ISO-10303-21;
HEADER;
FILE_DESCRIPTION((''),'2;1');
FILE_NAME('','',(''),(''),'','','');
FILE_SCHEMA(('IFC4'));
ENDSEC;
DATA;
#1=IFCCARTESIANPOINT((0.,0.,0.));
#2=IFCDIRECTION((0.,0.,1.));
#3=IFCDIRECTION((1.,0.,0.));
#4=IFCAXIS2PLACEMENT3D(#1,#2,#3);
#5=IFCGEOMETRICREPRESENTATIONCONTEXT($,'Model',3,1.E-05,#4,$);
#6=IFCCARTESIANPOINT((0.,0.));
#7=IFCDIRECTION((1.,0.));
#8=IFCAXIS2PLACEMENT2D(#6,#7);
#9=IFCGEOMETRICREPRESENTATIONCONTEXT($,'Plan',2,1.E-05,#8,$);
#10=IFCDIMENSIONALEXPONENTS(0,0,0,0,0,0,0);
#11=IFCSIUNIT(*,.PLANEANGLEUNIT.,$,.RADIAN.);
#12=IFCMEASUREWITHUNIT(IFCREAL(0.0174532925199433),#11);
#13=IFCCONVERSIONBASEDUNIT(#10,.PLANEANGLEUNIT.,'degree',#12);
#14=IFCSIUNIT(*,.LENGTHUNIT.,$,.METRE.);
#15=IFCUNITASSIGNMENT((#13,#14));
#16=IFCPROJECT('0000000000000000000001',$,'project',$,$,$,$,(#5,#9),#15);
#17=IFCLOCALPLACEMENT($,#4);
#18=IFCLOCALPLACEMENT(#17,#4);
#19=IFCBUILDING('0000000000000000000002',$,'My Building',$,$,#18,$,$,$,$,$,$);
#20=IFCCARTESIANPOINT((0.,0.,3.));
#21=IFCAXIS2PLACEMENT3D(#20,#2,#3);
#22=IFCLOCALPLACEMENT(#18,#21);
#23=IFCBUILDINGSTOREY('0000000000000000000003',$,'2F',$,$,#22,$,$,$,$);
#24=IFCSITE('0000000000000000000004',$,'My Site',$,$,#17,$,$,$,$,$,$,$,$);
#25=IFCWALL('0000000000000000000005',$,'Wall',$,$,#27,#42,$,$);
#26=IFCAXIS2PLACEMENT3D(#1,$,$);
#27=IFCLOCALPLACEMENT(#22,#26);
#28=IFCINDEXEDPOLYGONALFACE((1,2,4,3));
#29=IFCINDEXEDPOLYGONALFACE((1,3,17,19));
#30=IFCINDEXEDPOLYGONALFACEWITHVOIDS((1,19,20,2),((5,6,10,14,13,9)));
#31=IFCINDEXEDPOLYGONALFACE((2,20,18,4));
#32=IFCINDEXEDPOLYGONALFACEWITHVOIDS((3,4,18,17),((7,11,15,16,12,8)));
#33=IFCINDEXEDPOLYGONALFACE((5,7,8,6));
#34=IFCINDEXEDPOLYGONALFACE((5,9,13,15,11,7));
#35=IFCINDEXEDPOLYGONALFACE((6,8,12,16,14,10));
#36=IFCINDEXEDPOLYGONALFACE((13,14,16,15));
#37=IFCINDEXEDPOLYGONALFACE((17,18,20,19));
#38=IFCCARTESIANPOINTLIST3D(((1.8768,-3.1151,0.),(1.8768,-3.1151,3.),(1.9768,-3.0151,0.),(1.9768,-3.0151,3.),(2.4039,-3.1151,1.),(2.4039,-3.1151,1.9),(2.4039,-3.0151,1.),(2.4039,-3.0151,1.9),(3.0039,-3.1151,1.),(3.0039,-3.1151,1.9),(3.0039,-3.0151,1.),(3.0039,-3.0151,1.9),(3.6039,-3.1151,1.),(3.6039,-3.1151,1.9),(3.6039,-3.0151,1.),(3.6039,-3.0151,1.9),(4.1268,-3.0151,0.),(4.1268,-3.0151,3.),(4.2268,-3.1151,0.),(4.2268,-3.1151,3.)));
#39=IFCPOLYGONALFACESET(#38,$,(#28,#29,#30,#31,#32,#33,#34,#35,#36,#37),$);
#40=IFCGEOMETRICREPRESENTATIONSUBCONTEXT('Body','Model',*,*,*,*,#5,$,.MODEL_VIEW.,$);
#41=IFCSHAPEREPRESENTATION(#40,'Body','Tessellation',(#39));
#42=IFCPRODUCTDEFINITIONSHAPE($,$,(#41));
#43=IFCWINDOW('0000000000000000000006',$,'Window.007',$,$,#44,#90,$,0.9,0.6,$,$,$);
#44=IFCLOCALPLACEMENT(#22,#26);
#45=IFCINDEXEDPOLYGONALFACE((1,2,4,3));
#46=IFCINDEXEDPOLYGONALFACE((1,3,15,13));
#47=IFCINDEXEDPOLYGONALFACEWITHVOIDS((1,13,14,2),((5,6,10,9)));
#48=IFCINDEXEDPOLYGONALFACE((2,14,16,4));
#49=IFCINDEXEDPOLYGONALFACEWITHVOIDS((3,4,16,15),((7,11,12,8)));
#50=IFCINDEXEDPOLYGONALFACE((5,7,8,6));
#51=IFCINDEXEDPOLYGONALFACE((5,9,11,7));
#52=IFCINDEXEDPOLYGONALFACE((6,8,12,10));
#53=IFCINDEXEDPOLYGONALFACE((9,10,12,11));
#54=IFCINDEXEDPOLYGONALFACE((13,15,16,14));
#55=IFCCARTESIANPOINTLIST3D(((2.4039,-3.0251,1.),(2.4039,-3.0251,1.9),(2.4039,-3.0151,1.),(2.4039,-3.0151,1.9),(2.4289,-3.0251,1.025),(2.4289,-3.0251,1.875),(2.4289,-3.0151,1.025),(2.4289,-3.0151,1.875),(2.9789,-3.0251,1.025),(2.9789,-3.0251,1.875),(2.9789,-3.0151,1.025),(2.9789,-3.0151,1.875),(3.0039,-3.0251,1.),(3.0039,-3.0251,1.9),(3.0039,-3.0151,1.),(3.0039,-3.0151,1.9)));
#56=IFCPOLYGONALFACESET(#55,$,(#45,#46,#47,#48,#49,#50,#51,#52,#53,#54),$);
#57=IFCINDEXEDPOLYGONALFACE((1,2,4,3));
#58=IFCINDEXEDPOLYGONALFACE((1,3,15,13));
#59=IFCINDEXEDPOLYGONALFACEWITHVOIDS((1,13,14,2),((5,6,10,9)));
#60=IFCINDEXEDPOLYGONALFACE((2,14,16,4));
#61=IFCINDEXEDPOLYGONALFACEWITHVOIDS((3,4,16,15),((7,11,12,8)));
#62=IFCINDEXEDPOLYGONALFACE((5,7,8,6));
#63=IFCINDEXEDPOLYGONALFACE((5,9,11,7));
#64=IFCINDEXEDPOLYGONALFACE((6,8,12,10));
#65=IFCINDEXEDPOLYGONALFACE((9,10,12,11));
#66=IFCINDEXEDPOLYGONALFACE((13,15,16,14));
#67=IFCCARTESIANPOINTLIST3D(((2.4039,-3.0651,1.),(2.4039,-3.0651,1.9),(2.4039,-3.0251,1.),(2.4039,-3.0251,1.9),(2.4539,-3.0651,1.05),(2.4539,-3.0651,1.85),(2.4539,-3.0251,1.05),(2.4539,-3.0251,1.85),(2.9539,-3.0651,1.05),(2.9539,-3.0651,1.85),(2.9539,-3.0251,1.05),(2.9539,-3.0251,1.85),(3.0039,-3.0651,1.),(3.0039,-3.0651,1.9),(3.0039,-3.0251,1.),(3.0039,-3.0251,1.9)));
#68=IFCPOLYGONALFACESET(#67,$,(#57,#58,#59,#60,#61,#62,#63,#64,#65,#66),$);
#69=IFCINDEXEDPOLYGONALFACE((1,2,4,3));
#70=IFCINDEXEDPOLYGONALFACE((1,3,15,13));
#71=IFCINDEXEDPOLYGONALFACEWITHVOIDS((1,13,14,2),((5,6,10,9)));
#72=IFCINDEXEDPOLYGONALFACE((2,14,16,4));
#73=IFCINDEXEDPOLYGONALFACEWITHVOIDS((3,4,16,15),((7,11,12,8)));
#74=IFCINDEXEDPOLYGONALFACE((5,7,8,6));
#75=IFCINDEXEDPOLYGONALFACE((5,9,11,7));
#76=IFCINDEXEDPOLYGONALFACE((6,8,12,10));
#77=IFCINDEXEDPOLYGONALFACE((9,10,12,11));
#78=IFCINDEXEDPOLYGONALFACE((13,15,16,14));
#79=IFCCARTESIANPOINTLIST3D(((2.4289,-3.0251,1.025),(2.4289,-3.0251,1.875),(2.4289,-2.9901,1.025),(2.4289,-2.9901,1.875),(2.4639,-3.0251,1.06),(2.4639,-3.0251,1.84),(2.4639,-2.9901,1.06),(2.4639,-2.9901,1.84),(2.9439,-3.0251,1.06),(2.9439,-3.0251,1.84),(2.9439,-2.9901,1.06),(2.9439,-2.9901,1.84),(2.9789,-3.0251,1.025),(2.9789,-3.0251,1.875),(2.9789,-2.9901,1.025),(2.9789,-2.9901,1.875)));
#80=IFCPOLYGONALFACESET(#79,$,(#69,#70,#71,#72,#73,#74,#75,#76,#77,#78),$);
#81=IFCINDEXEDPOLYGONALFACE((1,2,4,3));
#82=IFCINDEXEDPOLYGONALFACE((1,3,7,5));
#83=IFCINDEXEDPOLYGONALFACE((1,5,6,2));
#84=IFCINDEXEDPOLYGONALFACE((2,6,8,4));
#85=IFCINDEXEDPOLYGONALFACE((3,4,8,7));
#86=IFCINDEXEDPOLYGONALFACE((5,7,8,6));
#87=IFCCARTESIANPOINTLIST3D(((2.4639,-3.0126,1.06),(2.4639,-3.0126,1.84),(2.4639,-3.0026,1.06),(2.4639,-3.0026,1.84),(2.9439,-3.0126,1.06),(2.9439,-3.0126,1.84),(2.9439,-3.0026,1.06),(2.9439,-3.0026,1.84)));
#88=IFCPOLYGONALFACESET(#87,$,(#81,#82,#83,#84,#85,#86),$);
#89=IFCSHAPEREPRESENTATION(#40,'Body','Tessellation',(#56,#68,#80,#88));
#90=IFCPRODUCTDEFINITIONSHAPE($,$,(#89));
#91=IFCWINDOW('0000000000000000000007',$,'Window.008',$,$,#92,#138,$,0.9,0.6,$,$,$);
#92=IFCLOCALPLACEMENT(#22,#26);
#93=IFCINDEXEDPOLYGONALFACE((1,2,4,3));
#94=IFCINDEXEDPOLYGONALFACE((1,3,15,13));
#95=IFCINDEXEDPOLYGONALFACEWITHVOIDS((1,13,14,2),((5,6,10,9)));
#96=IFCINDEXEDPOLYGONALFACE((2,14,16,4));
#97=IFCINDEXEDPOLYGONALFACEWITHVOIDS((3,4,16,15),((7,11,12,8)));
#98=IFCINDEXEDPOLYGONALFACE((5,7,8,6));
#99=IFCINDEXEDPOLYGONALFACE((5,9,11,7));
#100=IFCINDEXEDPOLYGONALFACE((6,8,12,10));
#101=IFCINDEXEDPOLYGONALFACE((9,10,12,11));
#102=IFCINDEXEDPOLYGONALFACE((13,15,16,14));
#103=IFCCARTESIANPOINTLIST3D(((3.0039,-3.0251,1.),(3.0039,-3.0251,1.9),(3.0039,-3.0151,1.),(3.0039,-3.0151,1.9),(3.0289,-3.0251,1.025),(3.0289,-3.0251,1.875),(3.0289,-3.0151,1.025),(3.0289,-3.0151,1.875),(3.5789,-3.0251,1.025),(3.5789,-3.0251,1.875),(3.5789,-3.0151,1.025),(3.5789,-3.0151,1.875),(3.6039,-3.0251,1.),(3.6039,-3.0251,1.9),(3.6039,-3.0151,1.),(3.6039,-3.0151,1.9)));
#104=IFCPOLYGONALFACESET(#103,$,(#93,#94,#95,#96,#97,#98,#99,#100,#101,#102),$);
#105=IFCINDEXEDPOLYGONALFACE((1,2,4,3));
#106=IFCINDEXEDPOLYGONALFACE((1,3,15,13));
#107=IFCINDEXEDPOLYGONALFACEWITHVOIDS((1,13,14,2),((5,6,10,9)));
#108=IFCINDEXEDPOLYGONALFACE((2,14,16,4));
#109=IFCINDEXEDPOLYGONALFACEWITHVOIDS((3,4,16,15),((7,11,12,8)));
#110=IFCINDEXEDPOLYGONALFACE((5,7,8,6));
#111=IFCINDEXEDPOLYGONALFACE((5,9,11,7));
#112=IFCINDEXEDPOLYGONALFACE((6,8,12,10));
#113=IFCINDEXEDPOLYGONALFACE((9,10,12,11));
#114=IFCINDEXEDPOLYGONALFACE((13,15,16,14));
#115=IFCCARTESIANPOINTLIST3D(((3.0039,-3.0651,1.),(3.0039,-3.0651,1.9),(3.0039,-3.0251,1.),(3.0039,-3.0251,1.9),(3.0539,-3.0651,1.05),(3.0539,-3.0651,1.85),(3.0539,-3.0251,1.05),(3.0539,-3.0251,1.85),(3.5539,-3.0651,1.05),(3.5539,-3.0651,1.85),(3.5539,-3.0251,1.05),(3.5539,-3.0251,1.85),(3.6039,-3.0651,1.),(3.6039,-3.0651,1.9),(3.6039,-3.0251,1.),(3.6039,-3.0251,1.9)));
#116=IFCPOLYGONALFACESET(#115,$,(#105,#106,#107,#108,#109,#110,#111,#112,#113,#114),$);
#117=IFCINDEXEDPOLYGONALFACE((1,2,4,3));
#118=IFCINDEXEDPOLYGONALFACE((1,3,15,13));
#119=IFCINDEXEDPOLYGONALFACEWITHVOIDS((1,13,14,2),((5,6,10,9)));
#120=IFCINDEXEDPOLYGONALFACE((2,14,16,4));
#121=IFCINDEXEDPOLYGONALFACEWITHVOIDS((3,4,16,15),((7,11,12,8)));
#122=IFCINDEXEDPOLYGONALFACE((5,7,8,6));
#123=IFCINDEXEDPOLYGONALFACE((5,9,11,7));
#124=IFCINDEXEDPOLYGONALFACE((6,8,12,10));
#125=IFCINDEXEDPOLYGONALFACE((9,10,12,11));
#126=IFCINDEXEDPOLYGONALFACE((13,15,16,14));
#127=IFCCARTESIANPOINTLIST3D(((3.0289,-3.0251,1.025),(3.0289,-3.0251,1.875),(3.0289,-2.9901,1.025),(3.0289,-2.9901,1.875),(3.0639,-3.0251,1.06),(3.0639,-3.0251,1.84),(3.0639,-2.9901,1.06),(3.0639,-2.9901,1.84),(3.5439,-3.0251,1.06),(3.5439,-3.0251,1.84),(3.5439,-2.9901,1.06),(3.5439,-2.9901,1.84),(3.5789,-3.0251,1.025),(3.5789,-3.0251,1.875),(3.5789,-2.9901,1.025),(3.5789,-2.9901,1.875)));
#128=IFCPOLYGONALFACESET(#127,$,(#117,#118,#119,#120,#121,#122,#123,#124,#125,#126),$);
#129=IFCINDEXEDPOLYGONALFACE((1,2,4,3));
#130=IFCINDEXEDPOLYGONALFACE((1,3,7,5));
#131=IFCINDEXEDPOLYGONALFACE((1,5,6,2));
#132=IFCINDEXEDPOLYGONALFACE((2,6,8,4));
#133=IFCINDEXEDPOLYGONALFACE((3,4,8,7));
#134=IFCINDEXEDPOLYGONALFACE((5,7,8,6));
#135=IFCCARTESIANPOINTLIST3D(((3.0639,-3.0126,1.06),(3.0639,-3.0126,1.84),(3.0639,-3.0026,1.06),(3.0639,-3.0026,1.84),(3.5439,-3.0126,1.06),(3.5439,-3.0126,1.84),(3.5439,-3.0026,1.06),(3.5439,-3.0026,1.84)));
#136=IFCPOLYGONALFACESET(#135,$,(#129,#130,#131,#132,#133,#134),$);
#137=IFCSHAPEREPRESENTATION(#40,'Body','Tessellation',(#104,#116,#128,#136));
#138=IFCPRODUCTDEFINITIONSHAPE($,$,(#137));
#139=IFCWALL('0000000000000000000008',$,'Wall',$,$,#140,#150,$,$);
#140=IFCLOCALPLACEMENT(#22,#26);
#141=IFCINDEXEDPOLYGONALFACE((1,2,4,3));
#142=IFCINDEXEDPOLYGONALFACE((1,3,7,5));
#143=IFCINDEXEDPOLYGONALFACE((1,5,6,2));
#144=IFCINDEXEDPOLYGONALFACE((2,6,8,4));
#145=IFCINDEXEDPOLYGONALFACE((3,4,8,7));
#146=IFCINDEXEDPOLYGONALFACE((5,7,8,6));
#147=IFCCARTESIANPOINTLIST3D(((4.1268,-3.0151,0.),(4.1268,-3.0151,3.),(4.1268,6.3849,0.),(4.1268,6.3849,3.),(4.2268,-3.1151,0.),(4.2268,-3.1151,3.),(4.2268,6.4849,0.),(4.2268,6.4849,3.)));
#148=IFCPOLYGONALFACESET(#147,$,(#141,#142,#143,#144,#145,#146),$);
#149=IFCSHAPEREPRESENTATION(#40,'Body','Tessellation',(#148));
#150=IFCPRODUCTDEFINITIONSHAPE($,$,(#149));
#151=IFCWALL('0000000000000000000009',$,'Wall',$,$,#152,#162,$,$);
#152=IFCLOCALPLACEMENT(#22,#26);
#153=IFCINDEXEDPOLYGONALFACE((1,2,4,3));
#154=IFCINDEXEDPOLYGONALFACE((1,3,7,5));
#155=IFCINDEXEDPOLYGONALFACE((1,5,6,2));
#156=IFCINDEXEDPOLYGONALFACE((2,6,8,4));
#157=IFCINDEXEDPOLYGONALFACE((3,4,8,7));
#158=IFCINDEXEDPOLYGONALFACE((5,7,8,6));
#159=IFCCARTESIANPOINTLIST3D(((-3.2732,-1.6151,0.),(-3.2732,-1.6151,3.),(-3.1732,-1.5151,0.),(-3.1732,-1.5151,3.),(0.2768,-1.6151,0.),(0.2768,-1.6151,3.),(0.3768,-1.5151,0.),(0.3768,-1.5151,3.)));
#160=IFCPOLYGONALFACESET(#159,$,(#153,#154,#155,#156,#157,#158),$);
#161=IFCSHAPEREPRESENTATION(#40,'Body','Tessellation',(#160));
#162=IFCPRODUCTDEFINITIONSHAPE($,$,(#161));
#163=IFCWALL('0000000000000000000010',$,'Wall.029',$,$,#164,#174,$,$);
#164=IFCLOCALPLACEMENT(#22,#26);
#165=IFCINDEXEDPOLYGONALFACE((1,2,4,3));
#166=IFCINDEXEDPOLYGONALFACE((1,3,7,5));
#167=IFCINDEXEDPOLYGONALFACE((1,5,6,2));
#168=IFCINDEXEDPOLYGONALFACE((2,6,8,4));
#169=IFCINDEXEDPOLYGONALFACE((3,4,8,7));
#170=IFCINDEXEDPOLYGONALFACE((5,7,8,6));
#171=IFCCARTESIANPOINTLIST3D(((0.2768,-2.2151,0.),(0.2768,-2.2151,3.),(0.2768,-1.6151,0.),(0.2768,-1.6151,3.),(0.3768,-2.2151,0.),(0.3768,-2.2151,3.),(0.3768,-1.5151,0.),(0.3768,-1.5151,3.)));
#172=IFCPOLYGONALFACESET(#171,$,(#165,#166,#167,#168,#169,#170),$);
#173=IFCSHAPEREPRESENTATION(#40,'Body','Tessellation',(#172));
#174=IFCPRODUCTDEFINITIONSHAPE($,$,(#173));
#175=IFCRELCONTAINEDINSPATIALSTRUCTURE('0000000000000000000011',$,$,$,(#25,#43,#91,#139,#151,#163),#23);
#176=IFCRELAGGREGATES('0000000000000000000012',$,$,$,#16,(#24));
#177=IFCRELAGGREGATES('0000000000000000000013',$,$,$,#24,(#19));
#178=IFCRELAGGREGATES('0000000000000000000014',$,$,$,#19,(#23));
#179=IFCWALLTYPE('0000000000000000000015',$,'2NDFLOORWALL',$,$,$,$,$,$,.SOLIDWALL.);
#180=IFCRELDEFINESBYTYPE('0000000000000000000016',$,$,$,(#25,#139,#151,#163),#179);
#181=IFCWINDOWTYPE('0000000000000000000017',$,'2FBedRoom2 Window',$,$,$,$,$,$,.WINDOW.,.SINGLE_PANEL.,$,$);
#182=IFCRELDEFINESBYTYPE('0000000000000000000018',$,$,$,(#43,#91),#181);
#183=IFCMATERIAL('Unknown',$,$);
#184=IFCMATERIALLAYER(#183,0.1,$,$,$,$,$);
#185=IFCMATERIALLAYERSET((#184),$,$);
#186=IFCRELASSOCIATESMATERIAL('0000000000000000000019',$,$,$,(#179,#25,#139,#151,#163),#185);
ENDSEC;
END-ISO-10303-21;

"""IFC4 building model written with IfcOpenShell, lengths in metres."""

from ifc_helpers import new_model, entity, si_unit, converted_unit, frame, origin_with_axes, origin_2d_with_axis, place, context, subcontext, project, spatial, line, indexed_curve, outline, extrude, shape, source, transform, mapped, material, layer, layer_set, layer_usage, type_object, type_shapes, element, fill, save


model = new_model("IFC4")

# Units and contexts
model_context = context("Model", 3, precision=1e-05, world=origin_with_axes())
plan_context = context("Plan", 2, precision=1e-05, world=origin_2d_with_axis())
body_context_1 = subcontext(model_context, "Body", "Model", "MODEL_VIEW")
body_context_2 = subcontext(plan_context, "Body", "Plan", "PLAN_VIEW")
ifc_project = project(units=[converted_unit("PLANEANGLEUNIT", "degree", entity("IfcReal", 0.0174532925199433), si_unit("PLANEANGLEUNIT", "RADIAN"), dimensions=[0, 0, 0, 0, 0, 0, 0]), si_unit("LENGTHUNIT", "METRE")], contexts=[model_context, plan_context])

# Site, building, storey
site_placement = place(None, origin_with_axes())
site = spatial("IfcSite", under=ifc_project, at=site_placement, Name="My Site")
building_placement = place(site_placement, origin_with_axes())
building = spatial("IfcBuilding", under=site, at=building_placement, Name="My Building")
storey_placement = place(building_placement, frame((0.0, 0.0, 3.0), z_axis=(0.0, 0.0, 1.0), x_axis=(1.0, 0.0, 0.0)))
storey = spatial("IfcBuildingStorey", under=building, at=storey_placement, Name="2F")

# Shared definitions
ifc_material = material(Name="Unknown")

# Shared definitions
ifc_layer_1 = layer(ifc_material, 0.1)
ifc_layer_set_1 = layer_set([ifc_layer_1])
wall_type_1 = type_object("IfcWallType", Name="2NDFLOORWALL", PredefinedType="SOLIDWALL", material=ifc_layer_set_1)

# Wall, openings, windows
ifc_layer_usage_1 = layer_usage(ifc_layer_set_1, "AXIS2", "POSITIVE", 0.0)
wall_1_placement = place(storey_placement, frame((1.8768, -3.1151, 0.0), z_axis=(0.0, 0.0, 1.0), x_axis=(1.0, 0.0, 0.0)))
wall_1 = element("IfcWall", 1, at=wall_1_placement, inside=storey, type_object=wall_type_1, material=ifc_layer_usage_1, Name="Wall", context=body_context_1, shape_type="SweptSolid", body=[
    extrude(outline(indexed_curve([(0.0, 0.0), (0.1, 0.1), (2.25, 0.1), (2.35, 0.0)], segments=[line(1, 2, 3, 4, 1)])), origin_with_axes(), (0.0, 0.0, 1.0), 3.0),
])
shared_shape_1 = source(origin_with_axes(), body_context_1, "Body", "SweptSolid", [
    extrude(outline(indexed_curve([(0.0, 0.0), (0.6, 0.0), (0.6, 0.9), (0.0, 0.9)], segments=[line(1, 2, 3, 4, 1)])), frame((0.0, -0.6, 0.0), z_axis=(0.0, -1.0, 0.0), x_axis=(1.0, 0.0, 0.0)), (0.0, 0.0, -1.0), 1.2),
])
opening_1_placement = place(wall_1_placement, frame((0.5271, 0.0, 1.0), z_axis=(0.0, 0.0, 1.0), x_axis=(1.0, 0.0, 0.0)))
opening_1 = element("IfcOpeningElement", 2, at=opening_1_placement, cuts=wall_1, PredefinedType="OPENING", context=body_context_1, shape_type="MappedRepresentation", body=[
    mapped(shared_shape_1, transform((0.0, 0.0, 0.0), x_axis=(1.0, 0.0, 0.0), y_axis=(0.0, 1.0, 0.0), z_axis=(0.0, 0.0, 1.0), scale=1.0)),
])
opening_2_placement = place(wall_1_placement, frame((1.1271, 0.0, 1.0), z_axis=(0.0, 0.0, 1.0), x_axis=(1.0, 0.0, 0.0)))
opening_2 = element("IfcOpeningElement", 3, at=opening_2_placement, cuts=wall_1, PredefinedType="OPENING", context=body_context_1, shape_type="MappedRepresentation", body=[
    mapped(shared_shape_1, transform((0.0, 0.0, 0.0), x_axis=(1.0, 0.0, 0.0), y_axis=(0.0, 1.0, 0.0), z_axis=(0.0, 0.0, 1.0), scale=1.0)),
])
window_type_1 = type_object("IfcWindowType", Name="2FBedRoom2 Window", PartitioningType="SINGLE_PANEL", PredefinedType="WINDOW")
shared_shape_2 = source(origin_with_axes(), body_context_1, "Body", "SweptSolid", [
    extrude(outline(indexed_curve([(0.0, 0.0), (0.6, 0.0), (0.6, 0.9), (0.0, 0.9)], segments=[line(1, 2, 3, 4, 1)]), holes=[indexed_curve([(0.025, 0.025), (0.575, 0.025), (0.575, 0.875), (0.025, 0.875)], segments=[line(1, 2, 3, 4, 1)])]), frame((0.0, 0.09, 0.0), z_axis=(0.0, -1.0, 0.0), x_axis=(1.0, 0.0, 0.0)), (0.0, 0.0, -1.0), 0.01),
    extrude(outline(indexed_curve([(0.0, 0.0), (0.6, 0.0), (0.6, 0.9), (0.0, 0.9)], segments=[line(1, 2, 3, 4, 1)]), holes=[indexed_curve([(0.05, 0.05), (0.55, 0.05), (0.55, 0.85), (0.05, 0.85)], segments=[line(1, 2, 3, 4, 1)])]), frame((0.0, 0.05, 0.0), z_axis=(0.0, -1.0, 0.0), x_axis=(1.0, 0.0, 0.0)), (0.0, 0.0, -1.0), 0.04),
    extrude(outline(indexed_curve([(0.0, 0.0), (0.55, 0.0), (0.55, 0.85), (0.0, 0.85)], segments=[line(1, 2, 3, 4, 1)]), holes=[indexed_curve([(0.035, 0.035), (0.515, 0.035), (0.515, 0.815), (0.035, 0.815)], segments=[line(1, 2, 3, 4, 1)])]), frame((0.025, 0.09, 0.025), z_axis=(0.0, -1.0, 0.0), x_axis=(1.0, 0.0, 0.0)), (0.0, 0.0, -1.0), 0.035),
    extrude(outline(indexed_curve([(0.035, 0.035), (0.515, 0.035), (0.515, 0.815), (0.035, 0.815)], segments=[line(1, 2, 3, 4, 1)])), frame((0.025, 0.1025, 0.025), z_axis=(0.0, -1.0, 0.0), x_axis=(1.0, 0.0, 0.0)), (0.0, 0.0, -1.0), 0.01),
])
shared_shape_3 = source(origin_with_axes(), body_context_2, "Body", "Curve2D", [
    entity("IfcIndexedPolyCurve", entity("IfcCartesianPointList2D", [[0.05, 0.05], [0.55, 0.05]])),
    entity("IfcIndexedPolyCurve", entity("IfcCartesianPointList2D", [[0.0, 0.1], [0.025, 0.1], [0.025, 0.09], [0.05, 0.09], [0.05, 0.05], [0.0, 0.05]]), [entity("IfcLineIndex", [1, 2, 3, 4, 5, 6, 1])]),
    entity("IfcIndexedPolyCurve", entity("IfcCartesianPointList2D", [[0.6, 0.1], [0.575, 0.1], [0.575, 0.09], [0.55, 0.09], [0.55, 0.05], [0.6, 0.05]]), [entity("IfcLineIndex", [1, 2, 3, 4, 5, 6, 1])]),
    entity("IfcIndexedPolyCurve", entity("IfcCartesianPointList2D", [[0.025, 0.09], [0.06, 0.09], [0.06, 0.125], [0.025, 0.125]]), [entity("IfcLineIndex", [1, 2, 3, 4, 1])]),
    entity("IfcIndexedPolyCurve", entity("IfcCartesianPointList2D", [[0.575, 0.09], [0.54, 0.09], [0.54, 0.125], [0.575, 0.125]]), [entity("IfcLineIndex", [1, 2, 3, 4, 1])]),
    entity("IfcIndexedPolyCurve", entity("IfcCartesianPointList2D", [[0.06, 0.09], [0.54, 0.09]])),
    entity("IfcIndexedPolyCurve", entity("IfcCartesianPointList2D", [[0.06, 0.125], [0.54, 0.125]])),
    entity("IfcIndexedPolyCurve", entity("IfcCartesianPointList2D", [[0.06, 0.1075], [0.54, 0.1075]])),
])
type_shapes(window_type_1, [shared_shape_2, shared_shape_3])
window_1_placement = place(opening_1_placement, origin_with_axes())
window_1 = element("IfcWindow", 4, at=window_1_placement, inside=storey, type_object=window_type_1, Name="Window.007", OverallHeight=0.9, OverallWidth=0.6, shapes=[
    shape(body_context_1, "Body", "MappedRepresentation", [mapped(shared_shape_2, transform((0.0, 0.0, 0.0), x_axis=(1.0, 0.0, 0.0), y_axis=(0.0, 1.0, 0.0), z_axis=(0.0, 0.0, 1.0), scale=1.0))]),
    shape(body_context_2, "Body", "MappedRepresentation", [mapped(shared_shape_3, transform((0.0, 0.0, 0.0), x_axis=(1.0, 0.0, 0.0), y_axis=(0.0, 1.0, 0.0), z_axis=(0.0, 0.0, 1.0), scale=1.0))]),
])
fill(opening_1, window_1)
window_2_placement = place(opening_2_placement, origin_with_axes())
window_2 = element("IfcWindow", 5, at=window_2_placement, inside=storey, type_object=window_type_1, Name="Window.008", OverallHeight=0.9, OverallWidth=0.6, shapes=[
    shape(body_context_1, "Body", "MappedRepresentation", [mapped(shared_shape_2, transform((0.0, 0.0, 0.0), x_axis=(1.0, 0.0, 0.0), y_axis=(0.0, 1.0, 0.0), z_axis=(0.0, 0.0, 1.0), scale=1.0))]),
    shape(body_context_2, "Body", "MappedRepresentation", [mapped(shared_shape_3, transform((0.0, 0.0, 0.0), x_axis=(1.0, 0.0, 0.0), y_axis=(0.0, 1.0, 0.0), z_axis=(0.0, 0.0, 1.0), scale=1.0))]),
])
fill(opening_2, window_2)

# Walls
ifc_layer_usage_2 = layer_usage(ifc_layer_set_1, "AXIS2", "POSITIVE", 0.0)
wall_2_placement = place(storey_placement, frame((4.2268, -3.1151, 0.0), z_axis=(0.0, 0.0, 1.0), x_axis=(0.0, 1.0, 0.0)))
element("IfcWall", 6, at=wall_2_placement, inside=storey, type_object=wall_type_1, material=ifc_layer_usage_2, Name="Wall", context=body_context_1, shape_type="SweptSolid", body=[
    extrude(outline(indexed_curve([(0.0, 0.0), (0.1, 0.1), (9.5, 0.1), (9.6, 0.0)], segments=[line(1, 2, 3, 4, 1)])), origin_with_axes(), (0.0, 0.0, 1.0), 3.0),
])
ifc_layer_usage_3 = layer_usage(ifc_layer_set_1, "AXIS2", "POSITIVE", 0.0)
wall_3_placement = place(storey_placement, frame((-3.2732, -1.6151, 0.0), z_axis=(0.0, 0.0, 1.0), x_axis=(1.0, 0.0, 0.0)))
element("IfcWall", 7, at=wall_3_placement, inside=storey, type_object=wall_type_1, material=ifc_layer_usage_3, Name="Wall", context=body_context_1, shape_type="SweptSolid", body=[
    extrude(outline(indexed_curve([(0.0, 0.0), (0.1, 0.1), (3.65, 0.1), (3.55, 0.0)], segments=[line(1, 2, 3, 4, 1)])), origin_with_axes(), (0.0, 0.0, 1.0), 3.0),
])
ifc_layer_usage_4 = layer_usage(ifc_layer_set_1, "AXIS2", "POSITIVE", 0.0)
wall_4_placement = place(storey_placement, frame((0.2768, -1.6151, 0.0), z_axis=(0.0, 0.0, 1.0), x_axis=(0.0, -1.0, 0.0)))
element("IfcWall", 8, at=wall_4_placement, inside=storey, type_object=wall_type_1, material=ifc_layer_usage_4, Name="Wall.029", context=body_context_1, shape_type="SweptSolid", body=[
    extrude(outline(indexed_curve([(0.0, 0.0), (-0.1, 0.1), (0.6, 0.1), (0.6, 0.0)], segments=[line(1, 2, 3, 4, 1)])), origin_with_axes(), (0.0, 0.0, 1.0), 3.0),
])

save(model, "model.ifc")
